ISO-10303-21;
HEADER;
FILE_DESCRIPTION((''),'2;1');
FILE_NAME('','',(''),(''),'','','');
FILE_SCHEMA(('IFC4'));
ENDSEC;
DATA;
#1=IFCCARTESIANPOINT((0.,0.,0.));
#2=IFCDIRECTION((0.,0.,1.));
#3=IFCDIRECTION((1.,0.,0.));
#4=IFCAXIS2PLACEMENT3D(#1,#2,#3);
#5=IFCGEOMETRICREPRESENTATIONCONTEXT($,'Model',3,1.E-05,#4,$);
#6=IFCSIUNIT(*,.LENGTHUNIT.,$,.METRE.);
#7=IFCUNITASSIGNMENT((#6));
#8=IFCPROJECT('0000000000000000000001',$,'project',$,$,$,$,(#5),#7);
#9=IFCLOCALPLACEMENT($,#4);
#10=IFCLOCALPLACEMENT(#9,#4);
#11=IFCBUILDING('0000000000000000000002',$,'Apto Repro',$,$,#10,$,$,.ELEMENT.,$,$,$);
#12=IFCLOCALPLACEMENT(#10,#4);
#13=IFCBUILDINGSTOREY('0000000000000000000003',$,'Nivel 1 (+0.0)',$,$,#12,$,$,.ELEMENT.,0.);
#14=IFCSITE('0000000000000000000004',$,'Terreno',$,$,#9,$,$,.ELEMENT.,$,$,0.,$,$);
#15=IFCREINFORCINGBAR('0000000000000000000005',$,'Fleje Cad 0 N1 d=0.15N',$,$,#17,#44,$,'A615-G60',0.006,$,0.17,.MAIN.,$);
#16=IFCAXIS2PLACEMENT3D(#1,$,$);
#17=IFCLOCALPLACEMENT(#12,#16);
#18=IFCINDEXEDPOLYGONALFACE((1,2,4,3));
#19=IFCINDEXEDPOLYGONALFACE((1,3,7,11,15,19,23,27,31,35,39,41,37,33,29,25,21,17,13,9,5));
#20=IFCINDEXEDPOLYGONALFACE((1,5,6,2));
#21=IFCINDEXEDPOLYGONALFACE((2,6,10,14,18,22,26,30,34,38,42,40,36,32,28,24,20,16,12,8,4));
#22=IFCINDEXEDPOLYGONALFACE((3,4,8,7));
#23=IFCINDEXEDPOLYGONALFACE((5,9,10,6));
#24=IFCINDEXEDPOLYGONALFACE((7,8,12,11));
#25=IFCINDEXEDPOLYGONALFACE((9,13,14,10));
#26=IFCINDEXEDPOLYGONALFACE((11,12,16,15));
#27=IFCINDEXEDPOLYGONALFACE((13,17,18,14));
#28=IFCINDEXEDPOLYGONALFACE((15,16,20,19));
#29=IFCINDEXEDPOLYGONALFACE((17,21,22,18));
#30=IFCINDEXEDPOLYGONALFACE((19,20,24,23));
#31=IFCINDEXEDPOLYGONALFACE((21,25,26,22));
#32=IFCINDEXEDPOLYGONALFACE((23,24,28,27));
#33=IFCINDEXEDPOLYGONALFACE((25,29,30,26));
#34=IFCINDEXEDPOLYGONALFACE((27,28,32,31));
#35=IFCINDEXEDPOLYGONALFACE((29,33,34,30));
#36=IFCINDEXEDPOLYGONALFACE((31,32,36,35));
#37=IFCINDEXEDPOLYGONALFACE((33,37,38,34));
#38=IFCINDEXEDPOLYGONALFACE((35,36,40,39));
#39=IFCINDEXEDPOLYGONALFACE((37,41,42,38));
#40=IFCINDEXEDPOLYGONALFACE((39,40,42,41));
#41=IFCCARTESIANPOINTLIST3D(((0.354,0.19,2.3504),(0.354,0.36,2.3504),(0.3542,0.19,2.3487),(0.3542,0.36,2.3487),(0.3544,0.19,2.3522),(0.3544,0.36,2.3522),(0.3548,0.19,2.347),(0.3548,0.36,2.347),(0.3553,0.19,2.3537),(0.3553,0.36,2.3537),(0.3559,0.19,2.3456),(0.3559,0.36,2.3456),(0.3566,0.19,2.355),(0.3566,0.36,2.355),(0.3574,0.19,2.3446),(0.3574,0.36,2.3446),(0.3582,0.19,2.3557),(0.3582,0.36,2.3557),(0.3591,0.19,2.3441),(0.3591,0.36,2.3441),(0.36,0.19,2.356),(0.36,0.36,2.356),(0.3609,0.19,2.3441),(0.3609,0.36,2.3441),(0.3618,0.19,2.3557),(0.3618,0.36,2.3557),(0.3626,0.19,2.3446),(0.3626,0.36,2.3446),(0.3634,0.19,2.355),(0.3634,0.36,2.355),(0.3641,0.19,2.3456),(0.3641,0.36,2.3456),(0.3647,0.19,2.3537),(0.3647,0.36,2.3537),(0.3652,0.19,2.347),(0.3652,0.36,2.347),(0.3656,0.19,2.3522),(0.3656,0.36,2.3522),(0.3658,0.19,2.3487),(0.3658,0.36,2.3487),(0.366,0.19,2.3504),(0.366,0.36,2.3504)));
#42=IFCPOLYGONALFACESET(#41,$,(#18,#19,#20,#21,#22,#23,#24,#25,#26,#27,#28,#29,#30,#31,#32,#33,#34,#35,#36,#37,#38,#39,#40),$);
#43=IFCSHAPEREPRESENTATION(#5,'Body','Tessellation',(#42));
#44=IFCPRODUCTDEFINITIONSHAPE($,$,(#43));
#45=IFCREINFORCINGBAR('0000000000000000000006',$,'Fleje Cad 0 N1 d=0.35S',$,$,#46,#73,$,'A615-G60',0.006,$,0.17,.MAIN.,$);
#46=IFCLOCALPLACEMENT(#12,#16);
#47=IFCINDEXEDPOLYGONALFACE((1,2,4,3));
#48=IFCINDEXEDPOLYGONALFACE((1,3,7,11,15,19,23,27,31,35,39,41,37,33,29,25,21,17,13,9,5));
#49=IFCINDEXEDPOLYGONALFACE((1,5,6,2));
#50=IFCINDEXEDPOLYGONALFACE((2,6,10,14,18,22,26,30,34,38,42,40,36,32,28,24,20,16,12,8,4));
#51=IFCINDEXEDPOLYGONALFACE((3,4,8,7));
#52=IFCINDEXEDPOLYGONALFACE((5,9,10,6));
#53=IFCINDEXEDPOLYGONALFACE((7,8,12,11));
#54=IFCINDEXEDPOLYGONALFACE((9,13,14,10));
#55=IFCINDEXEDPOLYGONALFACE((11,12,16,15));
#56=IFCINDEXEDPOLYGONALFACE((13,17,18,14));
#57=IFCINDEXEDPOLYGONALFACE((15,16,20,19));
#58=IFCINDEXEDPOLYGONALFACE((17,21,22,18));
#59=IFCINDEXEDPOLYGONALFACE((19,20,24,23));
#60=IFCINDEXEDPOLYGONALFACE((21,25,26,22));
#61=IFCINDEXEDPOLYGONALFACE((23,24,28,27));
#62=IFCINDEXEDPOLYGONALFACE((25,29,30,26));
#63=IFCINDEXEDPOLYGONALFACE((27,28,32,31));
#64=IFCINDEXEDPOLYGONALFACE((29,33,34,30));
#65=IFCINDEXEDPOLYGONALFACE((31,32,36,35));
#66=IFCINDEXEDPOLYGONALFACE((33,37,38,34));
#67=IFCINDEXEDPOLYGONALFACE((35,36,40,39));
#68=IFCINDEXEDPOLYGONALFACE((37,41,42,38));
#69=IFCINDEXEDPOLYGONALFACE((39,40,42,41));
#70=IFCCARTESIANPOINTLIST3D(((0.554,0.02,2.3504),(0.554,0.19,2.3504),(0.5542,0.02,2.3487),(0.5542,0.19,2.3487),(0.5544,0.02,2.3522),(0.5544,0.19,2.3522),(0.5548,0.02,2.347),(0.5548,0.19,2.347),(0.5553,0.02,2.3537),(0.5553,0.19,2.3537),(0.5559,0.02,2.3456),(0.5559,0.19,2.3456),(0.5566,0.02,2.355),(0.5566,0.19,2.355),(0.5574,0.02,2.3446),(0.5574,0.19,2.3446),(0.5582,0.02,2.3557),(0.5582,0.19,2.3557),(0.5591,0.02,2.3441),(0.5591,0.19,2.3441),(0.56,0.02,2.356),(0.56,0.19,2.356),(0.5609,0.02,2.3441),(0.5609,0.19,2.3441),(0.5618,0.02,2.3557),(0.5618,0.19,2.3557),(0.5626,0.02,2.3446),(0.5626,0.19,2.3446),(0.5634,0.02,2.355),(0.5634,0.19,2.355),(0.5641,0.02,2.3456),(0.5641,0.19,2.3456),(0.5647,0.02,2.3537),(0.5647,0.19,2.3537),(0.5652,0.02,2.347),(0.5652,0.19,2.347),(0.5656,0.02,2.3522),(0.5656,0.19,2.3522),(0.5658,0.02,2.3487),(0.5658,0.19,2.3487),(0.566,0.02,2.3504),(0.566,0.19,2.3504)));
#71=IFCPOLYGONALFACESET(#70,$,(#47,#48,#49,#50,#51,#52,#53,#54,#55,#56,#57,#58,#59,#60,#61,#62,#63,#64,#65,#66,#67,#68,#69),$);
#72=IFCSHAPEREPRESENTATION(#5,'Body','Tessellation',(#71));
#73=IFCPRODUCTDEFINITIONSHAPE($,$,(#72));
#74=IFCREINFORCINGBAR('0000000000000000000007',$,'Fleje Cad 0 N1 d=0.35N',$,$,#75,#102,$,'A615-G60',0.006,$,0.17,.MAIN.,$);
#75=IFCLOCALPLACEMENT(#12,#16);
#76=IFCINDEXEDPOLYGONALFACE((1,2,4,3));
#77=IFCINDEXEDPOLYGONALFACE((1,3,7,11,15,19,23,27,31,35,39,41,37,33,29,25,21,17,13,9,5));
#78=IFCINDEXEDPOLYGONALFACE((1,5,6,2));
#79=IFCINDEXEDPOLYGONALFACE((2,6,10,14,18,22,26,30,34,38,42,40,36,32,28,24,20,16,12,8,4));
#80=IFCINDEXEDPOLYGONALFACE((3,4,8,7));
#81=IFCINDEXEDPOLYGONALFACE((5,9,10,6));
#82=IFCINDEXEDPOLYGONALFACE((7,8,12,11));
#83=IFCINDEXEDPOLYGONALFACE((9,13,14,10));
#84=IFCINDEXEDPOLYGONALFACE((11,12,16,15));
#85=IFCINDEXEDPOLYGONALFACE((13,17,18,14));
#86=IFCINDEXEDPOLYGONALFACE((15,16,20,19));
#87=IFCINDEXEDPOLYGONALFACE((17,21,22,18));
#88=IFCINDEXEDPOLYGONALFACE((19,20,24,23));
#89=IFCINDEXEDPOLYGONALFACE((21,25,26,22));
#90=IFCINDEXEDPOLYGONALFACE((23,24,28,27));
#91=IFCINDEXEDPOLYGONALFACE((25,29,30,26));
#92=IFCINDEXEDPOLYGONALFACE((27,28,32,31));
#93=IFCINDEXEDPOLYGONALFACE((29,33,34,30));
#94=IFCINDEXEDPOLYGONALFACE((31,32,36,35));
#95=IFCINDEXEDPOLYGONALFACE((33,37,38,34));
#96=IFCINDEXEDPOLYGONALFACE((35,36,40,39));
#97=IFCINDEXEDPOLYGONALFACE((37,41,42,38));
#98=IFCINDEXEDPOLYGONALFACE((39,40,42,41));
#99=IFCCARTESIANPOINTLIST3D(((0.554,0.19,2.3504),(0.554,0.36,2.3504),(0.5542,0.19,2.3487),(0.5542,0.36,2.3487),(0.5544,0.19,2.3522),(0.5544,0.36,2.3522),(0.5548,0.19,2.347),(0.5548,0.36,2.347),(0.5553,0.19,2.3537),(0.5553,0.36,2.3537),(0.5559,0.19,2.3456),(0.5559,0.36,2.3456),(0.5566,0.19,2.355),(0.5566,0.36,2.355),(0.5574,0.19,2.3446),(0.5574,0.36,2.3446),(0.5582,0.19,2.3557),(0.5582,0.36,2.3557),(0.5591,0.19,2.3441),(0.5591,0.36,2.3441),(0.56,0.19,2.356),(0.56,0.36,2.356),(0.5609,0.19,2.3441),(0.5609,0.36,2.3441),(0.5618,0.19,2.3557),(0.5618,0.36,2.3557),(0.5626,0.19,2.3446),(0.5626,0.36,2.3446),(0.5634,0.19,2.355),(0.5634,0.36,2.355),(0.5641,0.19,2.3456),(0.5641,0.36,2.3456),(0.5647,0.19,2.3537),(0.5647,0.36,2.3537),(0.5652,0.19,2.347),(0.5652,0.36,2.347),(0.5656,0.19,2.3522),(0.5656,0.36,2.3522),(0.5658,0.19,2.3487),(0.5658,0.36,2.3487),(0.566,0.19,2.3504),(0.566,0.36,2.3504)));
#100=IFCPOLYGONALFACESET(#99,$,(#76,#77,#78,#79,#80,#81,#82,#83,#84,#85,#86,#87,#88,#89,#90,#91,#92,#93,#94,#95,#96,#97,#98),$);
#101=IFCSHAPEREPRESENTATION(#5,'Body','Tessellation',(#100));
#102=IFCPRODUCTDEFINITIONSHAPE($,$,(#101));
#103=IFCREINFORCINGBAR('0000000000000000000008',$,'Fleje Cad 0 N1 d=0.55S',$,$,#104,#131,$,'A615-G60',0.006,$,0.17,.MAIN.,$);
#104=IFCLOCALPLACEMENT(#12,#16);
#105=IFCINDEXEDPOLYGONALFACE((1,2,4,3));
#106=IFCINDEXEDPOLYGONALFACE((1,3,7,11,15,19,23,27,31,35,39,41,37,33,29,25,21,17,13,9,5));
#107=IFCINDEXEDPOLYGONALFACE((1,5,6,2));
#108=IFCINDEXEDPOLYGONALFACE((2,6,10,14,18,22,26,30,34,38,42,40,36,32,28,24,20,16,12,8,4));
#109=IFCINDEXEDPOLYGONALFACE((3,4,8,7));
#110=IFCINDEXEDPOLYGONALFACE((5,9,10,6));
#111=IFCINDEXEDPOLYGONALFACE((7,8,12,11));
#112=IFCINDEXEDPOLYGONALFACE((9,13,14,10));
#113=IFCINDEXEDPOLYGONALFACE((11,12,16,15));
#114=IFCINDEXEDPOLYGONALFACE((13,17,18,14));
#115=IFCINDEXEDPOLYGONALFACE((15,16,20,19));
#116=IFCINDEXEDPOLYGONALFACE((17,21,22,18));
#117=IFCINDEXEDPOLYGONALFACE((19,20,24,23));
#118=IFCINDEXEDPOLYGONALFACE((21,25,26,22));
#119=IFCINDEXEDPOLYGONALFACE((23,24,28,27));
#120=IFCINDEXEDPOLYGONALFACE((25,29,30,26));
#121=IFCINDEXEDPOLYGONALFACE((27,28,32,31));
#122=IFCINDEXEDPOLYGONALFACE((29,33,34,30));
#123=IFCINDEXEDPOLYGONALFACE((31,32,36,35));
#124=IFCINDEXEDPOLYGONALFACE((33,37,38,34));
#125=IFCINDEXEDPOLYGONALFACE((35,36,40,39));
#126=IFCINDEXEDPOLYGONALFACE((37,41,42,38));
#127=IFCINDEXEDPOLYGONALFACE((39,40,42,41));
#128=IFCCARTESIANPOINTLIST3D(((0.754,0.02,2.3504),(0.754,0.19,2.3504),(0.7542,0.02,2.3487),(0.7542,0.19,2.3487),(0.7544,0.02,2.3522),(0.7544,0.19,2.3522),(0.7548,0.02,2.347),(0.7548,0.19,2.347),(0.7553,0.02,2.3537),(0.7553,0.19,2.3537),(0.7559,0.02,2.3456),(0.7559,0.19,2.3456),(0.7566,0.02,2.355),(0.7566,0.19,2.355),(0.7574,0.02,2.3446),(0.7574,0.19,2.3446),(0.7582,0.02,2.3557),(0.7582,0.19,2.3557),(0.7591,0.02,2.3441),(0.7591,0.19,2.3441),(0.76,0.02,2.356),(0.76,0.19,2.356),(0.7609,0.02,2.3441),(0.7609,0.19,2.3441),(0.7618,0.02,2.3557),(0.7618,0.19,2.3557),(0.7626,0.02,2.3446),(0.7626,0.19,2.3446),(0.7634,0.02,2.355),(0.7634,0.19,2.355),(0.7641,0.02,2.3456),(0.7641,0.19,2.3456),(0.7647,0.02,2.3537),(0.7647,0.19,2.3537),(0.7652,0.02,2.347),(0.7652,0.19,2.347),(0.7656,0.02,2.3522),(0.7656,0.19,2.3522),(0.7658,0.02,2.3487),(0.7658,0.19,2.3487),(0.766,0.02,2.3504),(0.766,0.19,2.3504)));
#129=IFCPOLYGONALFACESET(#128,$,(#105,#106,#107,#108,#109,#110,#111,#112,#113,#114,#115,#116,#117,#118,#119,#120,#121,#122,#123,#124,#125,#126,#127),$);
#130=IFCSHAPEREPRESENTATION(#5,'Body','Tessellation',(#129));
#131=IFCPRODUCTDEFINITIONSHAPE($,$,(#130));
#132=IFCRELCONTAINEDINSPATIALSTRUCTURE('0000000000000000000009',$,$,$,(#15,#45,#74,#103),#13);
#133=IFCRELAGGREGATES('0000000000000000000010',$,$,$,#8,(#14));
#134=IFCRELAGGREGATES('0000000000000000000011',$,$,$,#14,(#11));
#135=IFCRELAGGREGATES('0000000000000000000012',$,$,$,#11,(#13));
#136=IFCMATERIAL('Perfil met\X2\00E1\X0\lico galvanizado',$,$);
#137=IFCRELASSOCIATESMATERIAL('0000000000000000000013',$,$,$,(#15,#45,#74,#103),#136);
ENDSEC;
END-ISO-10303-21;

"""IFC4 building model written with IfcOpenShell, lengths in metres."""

from ifc_helpers import new_model, si_unit, frame, origin_with_axes, origin_2d_with_axis, place, context, project, spatial, circle, extrude, material, element, save


model = new_model("IFC4")

# Units and contexts
model_context = context("Model", 3, precision=1e-05, world=origin_with_axes())
ifc_project = project(units=[si_unit("LENGTHUNIT", "METRE")], contexts=[model_context])

# Site, building, storey
site_placement = place(None, origin_with_axes())
site = spatial("IfcSite", under=ifc_project, at=site_placement, Name="Terreno", CompositionType="ELEMENT", RefElevation=0.0)
building_placement = place(site_placement, origin_with_axes())
building = spatial("IfcBuilding", under=site, at=building_placement, Name="Apto Repro", CompositionType="ELEMENT")
storey_placement = place(building_placement, origin_with_axes())
storey = spatial("IfcBuildingStorey", under=building, at=storey_placement, Name="Nivel 1 (+0.0)", CompositionType="ELEMENT", Elevation=0.0)

# Reinforcing bars
ifc_material = material(Name="Perfil metálico galvanizado")
reinforcing_bar_1_placement = place(storey_placement, origin_with_axes())
element("IfcReinforcingBar", 1, at=reinforcing_bar_1_placement, inside=storey, material=ifc_material, Name="Fleje Cad 0 N1 d=0.15N", SteelGrade="A615-G60", BarLength=0.17, NominalDiameter=0.006, PredefinedType="MAIN", context=model_context, shape_type="SweptSolid", body=[
    extrude(circle(Radius=0.006, at=origin_2d_with_axis()), frame((0.36, 0.19, 2.35), z_axis=(0.0, 1.0, 0.0), x_axis=(0.0, 0.0, 1.0)), (0.0, 0.0, 1.0), 0.17),
])
reinforcing_bar_2_placement = place(storey_placement, origin_with_axes())
element("IfcReinforcingBar", 2, at=reinforcing_bar_2_placement, inside=storey, material=ifc_material, Name="Fleje Cad 0 N1 d=0.35S", SteelGrade="A615-G60", BarLength=0.17, NominalDiameter=0.006, PredefinedType="MAIN", context=model_context, shape_type="SweptSolid", body=[
    extrude(circle(Radius=0.006, at=origin_2d_with_axis()), frame((0.56, 0.02, 2.35), z_axis=(0.0, 1.0, 0.0), x_axis=(0.0, 0.0, 1.0)), (0.0, 0.0, 1.0), 0.17),
])
reinforcing_bar_3_placement = place(storey_placement, origin_with_axes())
element("IfcReinforcingBar", 3, at=reinforcing_bar_3_placement, inside=storey, material=ifc_material, Name="Fleje Cad 0 N1 d=0.35N", SteelGrade="A615-G60", BarLength=0.17, NominalDiameter=0.006, PredefinedType="MAIN", context=model_context, shape_type="SweptSolid", body=[
    extrude(circle(Radius=0.006, at=origin_2d_with_axis()), frame((0.56, 0.19, 2.35), z_axis=(0.0, 1.0, 0.0), x_axis=(0.0, 0.0, 1.0)), (0.0, 0.0, 1.0), 0.17),
])
reinforcing_bar_4_placement = place(storey_placement, origin_with_axes())
element("IfcReinforcingBar", 4, at=reinforcing_bar_4_placement, inside=storey, material=ifc_material, Name="Fleje Cad 0 N1 d=0.55S", SteelGrade="A615-G60", BarLength=0.17, NominalDiameter=0.006, PredefinedType="MAIN", context=model_context, shape_type="SweptSolid", body=[
    extrude(circle(Radius=0.006, at=origin_2d_with_axis()), frame((0.76, 0.02, 2.35), z_axis=(0.0, 1.0, 0.0), x_axis=(0.0, 0.0, 1.0)), (0.0, 0.0, 1.0), 0.17),
])

save(model, "model.ifc")
